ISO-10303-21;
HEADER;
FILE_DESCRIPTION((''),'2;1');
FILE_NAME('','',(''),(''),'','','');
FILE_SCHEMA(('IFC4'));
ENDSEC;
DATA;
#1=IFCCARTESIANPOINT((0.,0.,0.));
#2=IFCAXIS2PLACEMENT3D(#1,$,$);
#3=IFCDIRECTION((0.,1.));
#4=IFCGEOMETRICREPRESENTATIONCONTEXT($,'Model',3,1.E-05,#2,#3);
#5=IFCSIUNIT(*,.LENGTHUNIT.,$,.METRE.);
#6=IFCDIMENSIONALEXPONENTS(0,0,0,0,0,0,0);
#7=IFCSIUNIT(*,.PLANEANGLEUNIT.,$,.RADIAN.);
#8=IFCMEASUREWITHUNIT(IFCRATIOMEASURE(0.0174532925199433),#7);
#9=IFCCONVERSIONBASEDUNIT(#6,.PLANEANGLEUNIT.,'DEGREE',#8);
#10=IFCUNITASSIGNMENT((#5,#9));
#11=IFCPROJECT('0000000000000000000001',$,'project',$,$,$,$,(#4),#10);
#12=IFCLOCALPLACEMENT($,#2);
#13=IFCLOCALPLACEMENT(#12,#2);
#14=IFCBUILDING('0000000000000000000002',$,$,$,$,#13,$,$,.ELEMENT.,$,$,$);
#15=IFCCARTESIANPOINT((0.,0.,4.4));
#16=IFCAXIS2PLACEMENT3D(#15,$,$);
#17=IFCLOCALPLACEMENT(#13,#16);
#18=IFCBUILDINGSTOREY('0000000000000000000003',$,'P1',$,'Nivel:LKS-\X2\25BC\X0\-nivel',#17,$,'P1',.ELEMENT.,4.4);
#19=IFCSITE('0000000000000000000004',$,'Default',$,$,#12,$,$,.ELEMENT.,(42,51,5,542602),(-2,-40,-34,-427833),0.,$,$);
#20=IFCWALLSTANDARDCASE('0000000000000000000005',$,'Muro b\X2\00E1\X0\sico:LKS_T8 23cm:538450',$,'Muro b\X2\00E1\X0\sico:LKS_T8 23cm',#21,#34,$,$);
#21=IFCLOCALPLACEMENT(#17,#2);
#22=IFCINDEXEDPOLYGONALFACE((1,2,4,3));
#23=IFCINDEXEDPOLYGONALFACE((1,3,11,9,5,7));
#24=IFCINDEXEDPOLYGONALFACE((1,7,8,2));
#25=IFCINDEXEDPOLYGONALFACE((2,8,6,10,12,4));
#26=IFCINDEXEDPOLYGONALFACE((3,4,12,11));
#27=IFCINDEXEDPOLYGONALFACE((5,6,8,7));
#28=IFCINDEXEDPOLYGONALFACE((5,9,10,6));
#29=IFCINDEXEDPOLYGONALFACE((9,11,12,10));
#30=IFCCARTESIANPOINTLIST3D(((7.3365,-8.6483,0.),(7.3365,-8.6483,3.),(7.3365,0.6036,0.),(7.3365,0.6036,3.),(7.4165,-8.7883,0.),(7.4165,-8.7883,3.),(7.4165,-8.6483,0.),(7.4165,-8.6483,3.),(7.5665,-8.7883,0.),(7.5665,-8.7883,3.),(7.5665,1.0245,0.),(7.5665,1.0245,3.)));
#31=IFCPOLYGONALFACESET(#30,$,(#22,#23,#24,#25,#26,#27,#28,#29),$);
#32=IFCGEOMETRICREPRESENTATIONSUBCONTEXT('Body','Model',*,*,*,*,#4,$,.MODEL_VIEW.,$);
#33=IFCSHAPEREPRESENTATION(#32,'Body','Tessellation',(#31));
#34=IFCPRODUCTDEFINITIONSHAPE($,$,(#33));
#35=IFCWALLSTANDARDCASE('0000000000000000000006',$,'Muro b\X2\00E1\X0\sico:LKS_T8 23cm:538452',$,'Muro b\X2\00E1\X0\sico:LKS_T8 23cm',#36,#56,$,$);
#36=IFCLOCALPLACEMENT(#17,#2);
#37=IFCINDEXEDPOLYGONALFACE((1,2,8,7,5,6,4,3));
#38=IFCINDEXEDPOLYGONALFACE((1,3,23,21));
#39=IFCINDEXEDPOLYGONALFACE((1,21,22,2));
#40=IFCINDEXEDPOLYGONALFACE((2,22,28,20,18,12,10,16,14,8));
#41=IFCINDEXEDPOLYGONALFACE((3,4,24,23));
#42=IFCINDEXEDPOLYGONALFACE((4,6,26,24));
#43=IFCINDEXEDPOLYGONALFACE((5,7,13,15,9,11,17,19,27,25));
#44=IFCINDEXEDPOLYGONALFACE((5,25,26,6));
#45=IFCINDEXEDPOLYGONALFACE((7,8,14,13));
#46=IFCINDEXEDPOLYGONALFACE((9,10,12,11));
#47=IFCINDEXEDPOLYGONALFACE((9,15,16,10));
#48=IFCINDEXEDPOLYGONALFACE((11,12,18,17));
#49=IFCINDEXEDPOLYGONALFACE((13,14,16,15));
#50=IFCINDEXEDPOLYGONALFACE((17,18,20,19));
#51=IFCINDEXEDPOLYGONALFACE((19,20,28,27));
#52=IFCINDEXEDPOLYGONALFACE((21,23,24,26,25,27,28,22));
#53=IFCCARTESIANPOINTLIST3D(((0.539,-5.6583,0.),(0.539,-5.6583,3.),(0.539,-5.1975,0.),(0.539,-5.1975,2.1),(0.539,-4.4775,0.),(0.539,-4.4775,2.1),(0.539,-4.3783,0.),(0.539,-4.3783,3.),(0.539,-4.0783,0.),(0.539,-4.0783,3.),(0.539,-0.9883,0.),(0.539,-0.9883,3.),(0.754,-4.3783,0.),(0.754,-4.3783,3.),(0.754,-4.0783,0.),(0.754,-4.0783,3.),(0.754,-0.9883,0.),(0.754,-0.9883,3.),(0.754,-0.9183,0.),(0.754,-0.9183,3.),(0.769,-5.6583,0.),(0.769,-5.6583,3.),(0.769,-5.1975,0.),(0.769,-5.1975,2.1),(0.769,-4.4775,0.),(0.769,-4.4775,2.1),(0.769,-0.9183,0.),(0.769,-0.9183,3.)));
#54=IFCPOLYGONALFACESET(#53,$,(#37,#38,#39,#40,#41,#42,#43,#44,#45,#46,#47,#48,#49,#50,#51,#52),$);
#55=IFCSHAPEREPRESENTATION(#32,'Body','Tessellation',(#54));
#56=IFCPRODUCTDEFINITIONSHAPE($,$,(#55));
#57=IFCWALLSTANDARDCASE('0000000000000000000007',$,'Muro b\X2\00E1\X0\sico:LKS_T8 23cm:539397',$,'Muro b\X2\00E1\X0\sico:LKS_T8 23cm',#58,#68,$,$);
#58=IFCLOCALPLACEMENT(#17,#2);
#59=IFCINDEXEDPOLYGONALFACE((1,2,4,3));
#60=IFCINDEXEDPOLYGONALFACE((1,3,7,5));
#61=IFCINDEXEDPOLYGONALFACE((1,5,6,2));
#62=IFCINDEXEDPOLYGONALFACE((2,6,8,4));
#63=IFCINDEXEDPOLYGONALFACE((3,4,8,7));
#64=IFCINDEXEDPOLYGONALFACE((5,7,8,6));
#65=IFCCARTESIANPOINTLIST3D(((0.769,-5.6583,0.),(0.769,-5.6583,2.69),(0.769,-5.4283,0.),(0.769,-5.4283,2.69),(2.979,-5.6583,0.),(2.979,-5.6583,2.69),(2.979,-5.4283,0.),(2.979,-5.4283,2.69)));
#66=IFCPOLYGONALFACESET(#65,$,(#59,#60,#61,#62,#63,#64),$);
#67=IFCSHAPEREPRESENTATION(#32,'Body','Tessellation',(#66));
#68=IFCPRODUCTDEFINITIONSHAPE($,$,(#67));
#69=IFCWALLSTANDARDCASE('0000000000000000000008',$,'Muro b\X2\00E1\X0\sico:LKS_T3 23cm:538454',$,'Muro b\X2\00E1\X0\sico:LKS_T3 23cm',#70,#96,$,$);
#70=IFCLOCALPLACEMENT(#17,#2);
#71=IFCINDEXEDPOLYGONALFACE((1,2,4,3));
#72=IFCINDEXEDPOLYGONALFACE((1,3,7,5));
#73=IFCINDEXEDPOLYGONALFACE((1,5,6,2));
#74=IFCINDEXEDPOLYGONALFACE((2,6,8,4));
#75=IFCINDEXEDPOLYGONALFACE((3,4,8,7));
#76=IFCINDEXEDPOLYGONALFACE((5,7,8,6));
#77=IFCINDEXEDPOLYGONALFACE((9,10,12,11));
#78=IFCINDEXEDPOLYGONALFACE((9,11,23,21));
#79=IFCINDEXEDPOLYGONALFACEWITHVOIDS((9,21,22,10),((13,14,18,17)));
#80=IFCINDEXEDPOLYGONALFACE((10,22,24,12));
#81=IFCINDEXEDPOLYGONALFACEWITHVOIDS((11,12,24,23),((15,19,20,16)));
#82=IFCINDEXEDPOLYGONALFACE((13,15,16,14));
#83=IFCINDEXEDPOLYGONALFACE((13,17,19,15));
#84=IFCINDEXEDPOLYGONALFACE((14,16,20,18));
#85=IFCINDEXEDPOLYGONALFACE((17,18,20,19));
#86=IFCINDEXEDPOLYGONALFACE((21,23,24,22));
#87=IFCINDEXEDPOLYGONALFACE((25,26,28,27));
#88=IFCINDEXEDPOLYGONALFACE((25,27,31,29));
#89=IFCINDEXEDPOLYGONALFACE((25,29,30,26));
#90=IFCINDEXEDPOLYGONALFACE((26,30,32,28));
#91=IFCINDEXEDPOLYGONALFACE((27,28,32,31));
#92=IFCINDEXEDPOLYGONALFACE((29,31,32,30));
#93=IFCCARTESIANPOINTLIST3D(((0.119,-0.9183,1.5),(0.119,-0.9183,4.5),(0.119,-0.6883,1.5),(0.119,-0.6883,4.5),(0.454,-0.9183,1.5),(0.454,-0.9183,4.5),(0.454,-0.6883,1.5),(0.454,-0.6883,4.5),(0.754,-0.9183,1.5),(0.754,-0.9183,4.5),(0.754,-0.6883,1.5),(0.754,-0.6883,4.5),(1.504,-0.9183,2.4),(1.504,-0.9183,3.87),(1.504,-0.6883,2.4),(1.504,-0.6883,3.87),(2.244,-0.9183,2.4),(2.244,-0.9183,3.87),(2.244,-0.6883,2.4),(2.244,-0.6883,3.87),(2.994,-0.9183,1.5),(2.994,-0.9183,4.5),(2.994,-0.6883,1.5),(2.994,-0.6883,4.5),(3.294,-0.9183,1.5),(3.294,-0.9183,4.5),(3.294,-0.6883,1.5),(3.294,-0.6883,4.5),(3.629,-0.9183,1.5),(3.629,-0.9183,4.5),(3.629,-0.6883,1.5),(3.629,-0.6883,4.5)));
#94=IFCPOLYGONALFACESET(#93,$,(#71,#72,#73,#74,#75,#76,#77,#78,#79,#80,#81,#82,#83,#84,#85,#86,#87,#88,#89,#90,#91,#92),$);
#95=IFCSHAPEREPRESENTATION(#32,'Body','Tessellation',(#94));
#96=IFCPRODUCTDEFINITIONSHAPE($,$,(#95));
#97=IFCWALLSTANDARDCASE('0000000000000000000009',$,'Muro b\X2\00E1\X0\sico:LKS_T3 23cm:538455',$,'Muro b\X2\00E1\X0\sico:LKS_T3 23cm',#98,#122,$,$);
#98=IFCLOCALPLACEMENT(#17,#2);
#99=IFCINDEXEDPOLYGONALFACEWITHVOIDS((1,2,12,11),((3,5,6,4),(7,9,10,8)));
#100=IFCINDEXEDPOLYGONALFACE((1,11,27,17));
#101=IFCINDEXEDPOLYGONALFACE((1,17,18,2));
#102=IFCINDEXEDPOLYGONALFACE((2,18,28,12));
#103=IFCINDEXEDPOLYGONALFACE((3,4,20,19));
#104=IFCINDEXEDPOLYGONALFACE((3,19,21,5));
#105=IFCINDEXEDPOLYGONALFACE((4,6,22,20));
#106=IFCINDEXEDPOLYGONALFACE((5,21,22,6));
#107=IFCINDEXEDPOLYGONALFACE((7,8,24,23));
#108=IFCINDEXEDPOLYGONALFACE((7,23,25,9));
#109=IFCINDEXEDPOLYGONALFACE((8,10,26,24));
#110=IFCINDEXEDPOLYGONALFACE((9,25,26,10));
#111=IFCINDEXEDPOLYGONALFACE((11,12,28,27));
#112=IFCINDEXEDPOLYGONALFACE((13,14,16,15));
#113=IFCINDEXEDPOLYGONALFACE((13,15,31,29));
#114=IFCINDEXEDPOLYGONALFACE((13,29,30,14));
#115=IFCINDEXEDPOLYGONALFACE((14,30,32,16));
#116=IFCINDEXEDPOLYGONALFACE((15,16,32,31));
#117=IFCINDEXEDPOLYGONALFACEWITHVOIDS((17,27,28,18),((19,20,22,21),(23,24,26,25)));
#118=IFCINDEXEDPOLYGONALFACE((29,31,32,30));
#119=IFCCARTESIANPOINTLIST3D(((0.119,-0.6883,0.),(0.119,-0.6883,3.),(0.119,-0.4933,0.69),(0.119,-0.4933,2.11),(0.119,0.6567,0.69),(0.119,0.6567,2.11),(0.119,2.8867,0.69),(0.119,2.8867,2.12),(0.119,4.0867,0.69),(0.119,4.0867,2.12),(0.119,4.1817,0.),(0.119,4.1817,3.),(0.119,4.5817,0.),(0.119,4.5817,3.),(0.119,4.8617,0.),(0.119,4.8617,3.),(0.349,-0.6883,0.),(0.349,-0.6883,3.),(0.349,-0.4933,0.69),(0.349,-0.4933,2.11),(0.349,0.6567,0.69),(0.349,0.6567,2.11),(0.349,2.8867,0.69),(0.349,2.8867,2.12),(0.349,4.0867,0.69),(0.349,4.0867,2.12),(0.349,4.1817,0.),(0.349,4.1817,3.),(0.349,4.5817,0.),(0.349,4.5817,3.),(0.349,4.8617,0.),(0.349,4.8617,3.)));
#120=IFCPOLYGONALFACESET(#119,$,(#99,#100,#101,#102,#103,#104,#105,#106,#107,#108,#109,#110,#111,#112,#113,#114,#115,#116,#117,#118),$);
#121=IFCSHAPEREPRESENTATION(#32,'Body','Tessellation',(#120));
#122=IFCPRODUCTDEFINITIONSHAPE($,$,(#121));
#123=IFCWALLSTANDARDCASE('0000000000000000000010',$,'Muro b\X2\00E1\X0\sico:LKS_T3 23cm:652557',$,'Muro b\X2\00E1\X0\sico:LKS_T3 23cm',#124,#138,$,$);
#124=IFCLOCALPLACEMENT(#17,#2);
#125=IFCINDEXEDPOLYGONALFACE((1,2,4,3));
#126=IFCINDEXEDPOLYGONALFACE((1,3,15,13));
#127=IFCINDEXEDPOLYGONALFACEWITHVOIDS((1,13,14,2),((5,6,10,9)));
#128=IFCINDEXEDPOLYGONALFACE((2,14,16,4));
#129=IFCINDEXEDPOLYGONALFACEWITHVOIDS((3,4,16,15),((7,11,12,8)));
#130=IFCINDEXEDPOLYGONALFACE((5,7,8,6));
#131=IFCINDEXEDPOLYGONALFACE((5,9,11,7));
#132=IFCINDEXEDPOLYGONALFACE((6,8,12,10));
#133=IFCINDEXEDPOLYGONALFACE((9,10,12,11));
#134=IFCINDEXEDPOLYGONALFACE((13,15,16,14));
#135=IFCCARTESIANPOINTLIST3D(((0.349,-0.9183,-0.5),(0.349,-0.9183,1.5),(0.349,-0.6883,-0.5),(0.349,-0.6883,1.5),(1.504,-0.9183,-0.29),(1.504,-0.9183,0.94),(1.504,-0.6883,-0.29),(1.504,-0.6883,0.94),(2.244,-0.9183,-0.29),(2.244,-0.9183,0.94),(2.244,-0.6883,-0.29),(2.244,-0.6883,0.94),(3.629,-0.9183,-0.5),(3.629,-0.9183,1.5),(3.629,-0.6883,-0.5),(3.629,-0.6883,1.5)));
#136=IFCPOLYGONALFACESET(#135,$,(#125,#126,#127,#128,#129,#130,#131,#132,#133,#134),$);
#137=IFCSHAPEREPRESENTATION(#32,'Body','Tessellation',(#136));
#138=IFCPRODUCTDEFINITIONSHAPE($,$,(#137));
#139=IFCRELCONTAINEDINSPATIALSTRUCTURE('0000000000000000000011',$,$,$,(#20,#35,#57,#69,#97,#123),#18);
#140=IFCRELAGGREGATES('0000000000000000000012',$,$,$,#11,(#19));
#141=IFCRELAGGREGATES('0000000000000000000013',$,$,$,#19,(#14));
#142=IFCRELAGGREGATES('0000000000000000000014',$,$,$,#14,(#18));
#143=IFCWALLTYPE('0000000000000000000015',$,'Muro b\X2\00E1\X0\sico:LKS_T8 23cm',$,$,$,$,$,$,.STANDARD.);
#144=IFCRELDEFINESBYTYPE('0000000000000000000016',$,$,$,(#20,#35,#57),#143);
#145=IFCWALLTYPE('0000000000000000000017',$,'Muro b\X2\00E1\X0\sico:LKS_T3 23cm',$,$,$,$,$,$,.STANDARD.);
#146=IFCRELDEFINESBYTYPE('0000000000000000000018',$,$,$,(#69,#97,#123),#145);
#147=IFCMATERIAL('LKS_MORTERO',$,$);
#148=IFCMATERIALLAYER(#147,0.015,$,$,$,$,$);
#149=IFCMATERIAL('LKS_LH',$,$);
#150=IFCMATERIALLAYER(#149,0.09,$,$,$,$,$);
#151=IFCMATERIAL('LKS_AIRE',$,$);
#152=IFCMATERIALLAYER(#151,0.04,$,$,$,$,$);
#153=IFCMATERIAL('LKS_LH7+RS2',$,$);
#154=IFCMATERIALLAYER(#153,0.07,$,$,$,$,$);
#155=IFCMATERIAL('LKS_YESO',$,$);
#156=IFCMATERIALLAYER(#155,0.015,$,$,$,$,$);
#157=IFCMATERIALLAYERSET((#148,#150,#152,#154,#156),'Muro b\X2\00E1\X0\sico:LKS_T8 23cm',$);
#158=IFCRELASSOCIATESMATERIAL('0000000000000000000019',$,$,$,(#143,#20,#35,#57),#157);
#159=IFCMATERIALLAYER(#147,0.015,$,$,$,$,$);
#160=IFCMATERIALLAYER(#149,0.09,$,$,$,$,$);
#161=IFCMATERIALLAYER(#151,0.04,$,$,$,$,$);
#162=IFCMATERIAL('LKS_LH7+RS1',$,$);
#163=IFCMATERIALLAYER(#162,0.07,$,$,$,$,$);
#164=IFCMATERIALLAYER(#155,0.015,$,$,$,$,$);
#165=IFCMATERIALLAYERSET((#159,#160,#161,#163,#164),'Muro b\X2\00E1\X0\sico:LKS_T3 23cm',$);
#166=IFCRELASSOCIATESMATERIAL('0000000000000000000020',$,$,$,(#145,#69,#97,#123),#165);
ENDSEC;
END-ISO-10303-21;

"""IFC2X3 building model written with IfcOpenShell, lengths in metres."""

from ifc_helpers import new_model, entity, si_unit, converted_unit, direction, frame, frame_2d, origin, place, context, subcontext, project, spatial, polyline, rectangle, outline, extrude, clip, bounded_halfspace, material, layer, layer_set, layer_usage, type_object, element, save


model = new_model("IFC2X3")

# Units and contexts
model_context = context("Model", 3, precision=1e-05, world=origin(), true_north=direction((0.0, 1.0)))
body_context = subcontext(model_context, "Body", "Model", "MODEL_VIEW")
ifc_project = project(units=[si_unit("LENGTHUNIT", "METRE"), converted_unit("PLANEANGLEUNIT", "DEGREE", entity("IfcRatioMeasure", 0.0174532925199433), si_unit("PLANEANGLEUNIT", "RADIAN"), dimensions=[0, 0, 0, 0, 0, 0, 0])], contexts=[model_context])

# Site, building, storey
site_placement = place(None, origin())
site = spatial("IfcSite", under=ifc_project, at=site_placement, Name="Default", CompositionType="ELEMENT", RefLatitude=(42, 51, 5, 542602), RefLongitude=(-2, -40, -34, -427833), RefElevation=0.0)
building_placement = place(site_placement, origin())
building = spatial("IfcBuilding", under=site, at=building_placement, CompositionType="ELEMENT")
storey_placement = place(building_placement, frame((0.0, 0.0, 4.4)))
storey = spatial("IfcBuildingStorey", under=building, at=storey_placement, Name="P1", ObjectType="Nivel:LKS-▼-nivel", LongName="P1", CompositionType="ELEMENT", Elevation=4.4)

# Wall
ifc_material_1 = material(Name="LKS_MORTERO")
ifc_layer_1 = layer(ifc_material_1, 0.015)
ifc_material_2 = material(Name="LKS_LH")
ifc_layer_2 = layer(ifc_material_2, 0.09)
ifc_material_3 = material(Name="LKS_AIRE")
ifc_layer_3 = layer(ifc_material_3, 0.04)
ifc_material_4 = material(Name="LKS_LH7+RS2")
ifc_layer_4 = layer(ifc_material_4, 0.07)
ifc_material_5 = material(Name="LKS_YESO")
ifc_layer_5 = layer(ifc_material_5, 0.015)
ifc_layer_set_1 = layer_set([ifc_layer_1, ifc_layer_2, ifc_layer_3, ifc_layer_4, ifc_layer_5], Name="Muro básico:LKS_T8 23cm")
ifc_layer_usage_1 = layer_usage(ifc_layer_set_1, "AXIS2", "POSITIVE", -0.115)
wall_type_1 = type_object("IfcWallType", Name="Muro básico:LKS_T8 23cm", PredefinedType="STANDARD", material=ifc_layer_set_1)
wall_1_placement = place(storey_placement, frame((7.4515, -8.7883, 0.0), z_axis=(0.0, 0.0, 1.0), x_axis=(0.0, 1.0, 0.0)))
element("IfcWallStandardCase", 1, at=wall_1_placement, inside=storey, type_object=wall_type_1, material=ifc_layer_usage_1, Name="Muro básico:LKS_T8 23cm:538450", ObjectType="Muro básico:LKS_T8 23cm", context=body_context, shape_type="Clipping", body=[
    clip(clip(extrude(outline(polyline([(9.8127, -0.115), (9.3919, 0.115), (4.59, 0.115), (4.49, 0.115), (0.14, 0.115), (0.14, 0.035), (0.0, 0.035), (0.0, -0.115), (9.4833, -0.115), (9.8127, -0.115)])), origin(), (0.0, 0.0, 1.0), 3.0), bounded_halfspace(frame((0.14, 0.035, 3.0), z_axis=(0.0, -1.0, 0.0), x_axis=(0.0, 0.0, -1.0)), True, frame((0.14, 0.035, 3.0), z_axis=(0.0, -1.0, 0.0), x_axis=(0.0, 0.0, -1.0)), polyline([(0.0, 0.0), (0.0, -0.14), (3.0, -0.14), (3.0, 0.0), (0.33, 0.0), (0.0, 0.0)]))), bounded_halfspace(frame((0.14, 0.035, 0.0), z_axis=(1.0, 0.0, 0.0), x_axis=(0.0, 0.0, -1.0)), True, frame((0.14, 0.035, 0.0), z_axis=(1.0, 0.0, 0.0), x_axis=(0.0, 0.0, -1.0)), polyline([(0.0, 0.0), (0.0, 0.08), (-3.0, 0.08), (-3.0, 0.0), (-2.67, 0.0), (0.0, 0.0)]))),
])

# Wall, openings
ifc_layer_usage_2 = layer_usage(ifc_layer_set_1, "AXIS2", "POSITIVE", -0.115)
wall_2_placement = place(storey_placement, frame((0.654, -5.6583, 0.0), z_axis=(0.0, 0.0, 1.0), x_axis=(0.0, 1.0, 0.0)))
wall_2 = element("IfcWallStandardCase", 2, at=wall_2_placement, inside=storey, type_object=wall_type_1, material=ifc_layer_usage_2, Name="Muro básico:LKS_T8 23cm:538452", ObjectType="Muro básico:LKS_T8 23cm", context=body_context, shape_type="Clipping", body=[
    clip(clip(extrude(rectangle(XDim=4.74, YDim=0.23, at=frame_2d((2.37, 0.0), x_axis=(-1.0, 0.0))), origin(), (0.0, 0.0, 1.0), 3.0), bounded_halfspace(frame((4.67, -0.1, 0.0), z_axis=(0.0, -1.0, 0.0), x_axis=(0.0, 0.0, -1.0)), True, frame((4.67, -0.1, 0.0), z_axis=(0.0, -1.0, 0.0), x_axis=(0.0, 0.0, -1.0)), polyline([(0.0, 0.0), (0.0, 0.07), (-1.5, 0.07), (-3.0, 0.07), (-3.0, 0.0), (0.0, 0.0)]))), bounded_halfspace(frame((4.67, -0.1, 3.0), z_axis=(-1.0, 0.0, 0.0), x_axis=(0.0, 0.0, -1.0)), True, frame((4.67, -0.1, 3.0), z_axis=(-1.0, 0.0, 0.0), x_axis=(0.0, 0.0, -1.0)), polyline([(0.0, 0.0), (0.0, -0.015), (0.0, -0.215), (3.0, -0.215), (3.0, 0.0), (0.0, 0.0)]))),
])
opening_1_placement = place(storey_placement, frame((0.654, -5.6583, 0.0), z_axis=(0.0, 0.0, 1.0), x_axis=(0.0, 1.0, 0.0)))
element("IfcOpeningElement", 3, at=opening_1_placement, cuts=wall_2, ObjectType="Opening", context=body_context, shape_type="SweptSolid", body=[
    extrude(rectangle(XDim=3.0, YDim=0.215, at=frame_2d((0.234, 0.0215), x_axis=(1.0, 0.0))), frame((1.28, -0.014, 1.734), z_axis=(1.0, 0.0, 0.0), x_axis=(0.0, 0.0, -1.0)), (0.0, 0.0, 1.0), 0.3),
])
opening_2_placement = place(wall_2_placement, origin())
element("IfcOpeningElement", 4, at=opening_2_placement, cuts=wall_2, ObjectType="Opening", context=body_context, shape_type="SweptSolid", body=[
    extrude(rectangle(XDim=2.1, YDim=0.72, at=frame_2d((0.0, 0.0), x_axis=(1.0, 0.0))), frame((0.8219, -1.639, 4.05), z_axis=(0.0, 1.0, 0.0), x_axis=(0.0, 0.0, 1.0)), (0.0, 0.0, 1.0), 3.048),
])
opening_3_placement = place(wall_2_placement, frame((0.4608, -0.115, 0.0)))
element("IfcOpeningElement", 5, at=opening_3_placement, cuts=wall_2, ObjectType="Opening", context=body_context, shape_type="SweptSolid", body=[
    extrude(rectangle(XDim=2.1, YDim=0.72, at=frame_2d((1.05, 0.36), x_axis=(1.0, 0.0))), frame((0.0, 0.0, 0.0), z_axis=(0.0, 1.0, 0.0), x_axis=(0.0, 0.0, 1.0)), (0.0, 0.0, 1.0), 0.23),
])

# Wall
ifc_layer_usage_3 = layer_usage(ifc_layer_set_1, "AXIS2", "POSITIVE", -0.115)
wall_3_placement = place(storey_placement, frame((2.979, -5.5433, 0.0), z_axis=(0.0, 0.0, 1.0), x_axis=(-1.0, 0.0, 0.0)))
element("IfcWallStandardCase", 6, at=wall_3_placement, inside=storey, type_object=wall_type_1, material=ifc_layer_usage_3, Name="Muro básico:LKS_T8 23cm:539397", ObjectType="Muro básico:LKS_T8 23cm", context=body_context, shape_type="SweptSolid", body=[
    extrude(rectangle(XDim=2.21, YDim=0.23, at=frame_2d((1.105, 0.0), x_axis=(-1.0, 0.0))), origin(), (0.0, 0.0, 1.0), 2.69),
])

# Walls, openings
ifc_layer_6 = layer(ifc_material_1, 0.015)
ifc_layer_7 = layer(ifc_material_2, 0.09)
ifc_layer_8 = layer(ifc_material_3, 0.04)
ifc_material_6 = material(Name="LKS_LH7+RS1")
ifc_layer_9 = layer(ifc_material_6, 0.07)
ifc_layer_10 = layer(ifc_material_5, 0.015)
ifc_layer_set_2 = layer_set([ifc_layer_6, ifc_layer_7, ifc_layer_8, ifc_layer_9, ifc_layer_10], Name="Muro básico:LKS_T3 23cm")
ifc_layer_usage_4 = layer_usage(ifc_layer_set_2, "AXIS2", "NEGATIVE", 0.115)
wall_type_2 = type_object("IfcWallType", Name="Muro básico:LKS_T3 23cm", PredefinedType="STANDARD", material=ifc_layer_set_2)
wall_4_placement = place(storey_placement, frame((3.629, -0.8033, 1.5), z_axis=(0.0, 0.0, 1.0), x_axis=(-1.0, 0.0, 0.0)))
wall_4 = element("IfcWallStandardCase", 7, at=wall_4_placement, inside=storey, type_object=wall_type_2, material=ifc_layer_usage_4, Name="Muro básico:LKS_T3 23cm:538454", ObjectType="Muro básico:LKS_T3 23cm", context=body_context, shape_type="SweptSolid", body=[
    extrude(rectangle(XDim=3.51, YDim=0.23, at=frame_2d((1.755, 0.0), x_axis=(-1.0, 0.0))), origin(), (0.0, 0.0, 1.0), 3.0),
])
opening_4_placement = place(storey_placement, frame((3.629, -0.8033, 1.5), z_axis=(0.0, 0.0, 1.0), x_axis=(-1.0, 0.0, 0.0)))
element("IfcOpeningElement", 8, at=opening_4_placement, cuts=wall_4, ObjectType="Opening", context=body_context, shape_type="SweptSolid", body=[
    extrude(rectangle(XDim=3.0, YDim=0.23, at=frame_2d((-0.023, 0.0), x_axis=(0.0, 1.0))), frame((3.175, -0.023, 1.5), z_axis=(-1.0, 0.0, 0.0), x_axis=(0.0, -1.0, 0.0)), (0.0, 0.0, 1.0), 0.3),
])
opening_5_placement = place(storey_placement, frame((3.629, -0.8033, 1.5), z_axis=(0.0, 0.0, 1.0), x_axis=(-1.0, 0.0, 0.0)))
element("IfcOpeningElement", 9, at=opening_5_placement, cuts=wall_4, ObjectType="Opening", context=body_context, shape_type="SweptSolid", body=[
    extrude(rectangle(XDim=3.0, YDim=0.23, at=frame_2d((0.0, 0.0), x_axis=(0.0, 1.0))), frame((0.635, 0.0, 1.5), z_axis=(-1.0, 0.0, 0.0), x_axis=(0.0, 1.0, 0.0)), (0.0, 0.0, 1.0), 0.3),
])
opening_6_placement = place(wall_4_placement, frame((2.125, 0.115, 0.9)))
element("IfcOpeningElement", 10, at=opening_6_placement, cuts=wall_4, ObjectType="Opening", context=body_context, shape_type="SweptSolid", body=[
    extrude(rectangle(XDim=1.47, YDim=0.74, at=frame_2d((0.735, 0.37), x_axis=(1.0, 0.0))), frame((0.0, 0.0, 0.0), z_axis=(0.0, -1.0, 0.0), x_axis=(0.0, 0.0, 1.0)), (0.0, 0.0, 1.0), 0.23),
])
ifc_layer_usage_5 = layer_usage(ifc_layer_set_2, "AXIS2", "POSITIVE", -0.115)
wall_5_placement = place(storey_placement, frame((0.234, -0.6883, 0.0), z_axis=(0.0, 0.0, 1.0), x_axis=(0.0, 1.0, 0.0)))
wall_5 = element("IfcWallStandardCase", 11, at=wall_5_placement, inside=storey, type_object=wall_type_2, material=ifc_layer_usage_5, Name="Muro básico:LKS_T3 23cm:538455", ObjectType="Muro básico:LKS_T3 23cm", context=body_context, shape_type="SweptSolid", body=[
    extrude(rectangle(XDim=5.55, YDim=0.23, at=frame_2d((2.775, 0.0), x_axis=(-1.0, 0.0))), origin(), (0.0, 0.0, 1.0), 3.0),
])
opening_7_placement = place(storey_placement, frame((0.234, -0.6883, 0.0), z_axis=(0.0, 0.0, 1.0), x_axis=(0.0, 1.0, 0.0)))
element("IfcOpeningElement", 12, at=opening_7_placement, cuts=wall_5, ObjectType="Opening", context=body_context, shape_type="SweptSolid", body=[
    extrude(rectangle(XDim=3.0, YDim=0.23, at=frame_2d((0.0, 0.0133), x_axis=(1.0, 0.0))), frame((4.87, -0.0133, 1.5), z_axis=(1.0, 0.0, 0.0), x_axis=(0.0, 0.0, -1.0)), (0.0, 0.0, 1.0), 0.4),
])
opening_8_placement = place(wall_5_placement, frame((3.575, -0.115, 0.69)))
element("IfcOpeningElement", 13, at=opening_8_placement, cuts=wall_5, ObjectType="Opening", context=body_context, shape_type="SweptSolid", body=[
    extrude(rectangle(XDim=1.43, YDim=1.2, at=frame_2d((0.715, 0.6), x_axis=(1.0, 0.0))), frame((0.0, 0.0, 0.0), z_axis=(0.0, 1.0, 0.0), x_axis=(0.0, 0.0, 1.0)), (0.0, 0.0, 1.0), 0.23),
])
opening_9_placement = place(wall_5_placement, frame((1.345, 0.115, 0.69)))
element("IfcOpeningElement", 14, at=opening_9_placement, cuts=wall_5, ObjectType="Opening", context=body_context, shape_type="SweptSolid", body=[
    extrude(rectangle(XDim=1.42, YDim=1.15, at=frame_2d((0.71, 0.575), x_axis=(1.0, 0.0))), frame((0.0, 0.0, 0.0), z_axis=(0.0, -1.0, 0.0), x_axis=(0.0, 0.0, 1.0)), (0.0, 0.0, 1.0), 0.23),
])

# Wall, opening
ifc_layer_usage_6 = layer_usage(ifc_layer_set_2, "AXIS2", "NEGATIVE", 0.115)
wall_6_placement = place(storey_placement, frame((3.629, -0.8033, -0.5), z_axis=(0.0, 0.0, 1.0), x_axis=(-1.0, 0.0, 0.0)))
wall_6 = element("IfcWallStandardCase", 15, at=wall_6_placement, inside=storey, type_object=wall_type_2, material=ifc_layer_usage_6, Name="Muro básico:LKS_T3 23cm:652557", ObjectType="Muro básico:LKS_T3 23cm", context=body_context, shape_type="SweptSolid", body=[
    extrude(rectangle(XDim=3.28, YDim=0.23, at=frame_2d((1.64, 0.0), x_axis=(-1.0, 0.0))), origin(), (0.0, 0.0, 1.0), 2.0),
])
opening_10_placement = place(wall_6_placement, frame((2.125, 0.115, 0.21)))
element("IfcOpeningElement", 16, at=opening_10_placement, cuts=wall_6, ObjectType="Opening", context=body_context, shape_type="SweptSolid", body=[
    extrude(rectangle(XDim=1.23, YDim=0.74, at=frame_2d((0.615, 0.37), x_axis=(1.0, 0.0))), frame((0.0, 0.0, 0.0), z_axis=(0.0, -1.0, 0.0), x_axis=(0.0, 0.0, 1.0)), (0.0, 0.0, 1.0), 0.23),
])

save(model, "model.ifc")
